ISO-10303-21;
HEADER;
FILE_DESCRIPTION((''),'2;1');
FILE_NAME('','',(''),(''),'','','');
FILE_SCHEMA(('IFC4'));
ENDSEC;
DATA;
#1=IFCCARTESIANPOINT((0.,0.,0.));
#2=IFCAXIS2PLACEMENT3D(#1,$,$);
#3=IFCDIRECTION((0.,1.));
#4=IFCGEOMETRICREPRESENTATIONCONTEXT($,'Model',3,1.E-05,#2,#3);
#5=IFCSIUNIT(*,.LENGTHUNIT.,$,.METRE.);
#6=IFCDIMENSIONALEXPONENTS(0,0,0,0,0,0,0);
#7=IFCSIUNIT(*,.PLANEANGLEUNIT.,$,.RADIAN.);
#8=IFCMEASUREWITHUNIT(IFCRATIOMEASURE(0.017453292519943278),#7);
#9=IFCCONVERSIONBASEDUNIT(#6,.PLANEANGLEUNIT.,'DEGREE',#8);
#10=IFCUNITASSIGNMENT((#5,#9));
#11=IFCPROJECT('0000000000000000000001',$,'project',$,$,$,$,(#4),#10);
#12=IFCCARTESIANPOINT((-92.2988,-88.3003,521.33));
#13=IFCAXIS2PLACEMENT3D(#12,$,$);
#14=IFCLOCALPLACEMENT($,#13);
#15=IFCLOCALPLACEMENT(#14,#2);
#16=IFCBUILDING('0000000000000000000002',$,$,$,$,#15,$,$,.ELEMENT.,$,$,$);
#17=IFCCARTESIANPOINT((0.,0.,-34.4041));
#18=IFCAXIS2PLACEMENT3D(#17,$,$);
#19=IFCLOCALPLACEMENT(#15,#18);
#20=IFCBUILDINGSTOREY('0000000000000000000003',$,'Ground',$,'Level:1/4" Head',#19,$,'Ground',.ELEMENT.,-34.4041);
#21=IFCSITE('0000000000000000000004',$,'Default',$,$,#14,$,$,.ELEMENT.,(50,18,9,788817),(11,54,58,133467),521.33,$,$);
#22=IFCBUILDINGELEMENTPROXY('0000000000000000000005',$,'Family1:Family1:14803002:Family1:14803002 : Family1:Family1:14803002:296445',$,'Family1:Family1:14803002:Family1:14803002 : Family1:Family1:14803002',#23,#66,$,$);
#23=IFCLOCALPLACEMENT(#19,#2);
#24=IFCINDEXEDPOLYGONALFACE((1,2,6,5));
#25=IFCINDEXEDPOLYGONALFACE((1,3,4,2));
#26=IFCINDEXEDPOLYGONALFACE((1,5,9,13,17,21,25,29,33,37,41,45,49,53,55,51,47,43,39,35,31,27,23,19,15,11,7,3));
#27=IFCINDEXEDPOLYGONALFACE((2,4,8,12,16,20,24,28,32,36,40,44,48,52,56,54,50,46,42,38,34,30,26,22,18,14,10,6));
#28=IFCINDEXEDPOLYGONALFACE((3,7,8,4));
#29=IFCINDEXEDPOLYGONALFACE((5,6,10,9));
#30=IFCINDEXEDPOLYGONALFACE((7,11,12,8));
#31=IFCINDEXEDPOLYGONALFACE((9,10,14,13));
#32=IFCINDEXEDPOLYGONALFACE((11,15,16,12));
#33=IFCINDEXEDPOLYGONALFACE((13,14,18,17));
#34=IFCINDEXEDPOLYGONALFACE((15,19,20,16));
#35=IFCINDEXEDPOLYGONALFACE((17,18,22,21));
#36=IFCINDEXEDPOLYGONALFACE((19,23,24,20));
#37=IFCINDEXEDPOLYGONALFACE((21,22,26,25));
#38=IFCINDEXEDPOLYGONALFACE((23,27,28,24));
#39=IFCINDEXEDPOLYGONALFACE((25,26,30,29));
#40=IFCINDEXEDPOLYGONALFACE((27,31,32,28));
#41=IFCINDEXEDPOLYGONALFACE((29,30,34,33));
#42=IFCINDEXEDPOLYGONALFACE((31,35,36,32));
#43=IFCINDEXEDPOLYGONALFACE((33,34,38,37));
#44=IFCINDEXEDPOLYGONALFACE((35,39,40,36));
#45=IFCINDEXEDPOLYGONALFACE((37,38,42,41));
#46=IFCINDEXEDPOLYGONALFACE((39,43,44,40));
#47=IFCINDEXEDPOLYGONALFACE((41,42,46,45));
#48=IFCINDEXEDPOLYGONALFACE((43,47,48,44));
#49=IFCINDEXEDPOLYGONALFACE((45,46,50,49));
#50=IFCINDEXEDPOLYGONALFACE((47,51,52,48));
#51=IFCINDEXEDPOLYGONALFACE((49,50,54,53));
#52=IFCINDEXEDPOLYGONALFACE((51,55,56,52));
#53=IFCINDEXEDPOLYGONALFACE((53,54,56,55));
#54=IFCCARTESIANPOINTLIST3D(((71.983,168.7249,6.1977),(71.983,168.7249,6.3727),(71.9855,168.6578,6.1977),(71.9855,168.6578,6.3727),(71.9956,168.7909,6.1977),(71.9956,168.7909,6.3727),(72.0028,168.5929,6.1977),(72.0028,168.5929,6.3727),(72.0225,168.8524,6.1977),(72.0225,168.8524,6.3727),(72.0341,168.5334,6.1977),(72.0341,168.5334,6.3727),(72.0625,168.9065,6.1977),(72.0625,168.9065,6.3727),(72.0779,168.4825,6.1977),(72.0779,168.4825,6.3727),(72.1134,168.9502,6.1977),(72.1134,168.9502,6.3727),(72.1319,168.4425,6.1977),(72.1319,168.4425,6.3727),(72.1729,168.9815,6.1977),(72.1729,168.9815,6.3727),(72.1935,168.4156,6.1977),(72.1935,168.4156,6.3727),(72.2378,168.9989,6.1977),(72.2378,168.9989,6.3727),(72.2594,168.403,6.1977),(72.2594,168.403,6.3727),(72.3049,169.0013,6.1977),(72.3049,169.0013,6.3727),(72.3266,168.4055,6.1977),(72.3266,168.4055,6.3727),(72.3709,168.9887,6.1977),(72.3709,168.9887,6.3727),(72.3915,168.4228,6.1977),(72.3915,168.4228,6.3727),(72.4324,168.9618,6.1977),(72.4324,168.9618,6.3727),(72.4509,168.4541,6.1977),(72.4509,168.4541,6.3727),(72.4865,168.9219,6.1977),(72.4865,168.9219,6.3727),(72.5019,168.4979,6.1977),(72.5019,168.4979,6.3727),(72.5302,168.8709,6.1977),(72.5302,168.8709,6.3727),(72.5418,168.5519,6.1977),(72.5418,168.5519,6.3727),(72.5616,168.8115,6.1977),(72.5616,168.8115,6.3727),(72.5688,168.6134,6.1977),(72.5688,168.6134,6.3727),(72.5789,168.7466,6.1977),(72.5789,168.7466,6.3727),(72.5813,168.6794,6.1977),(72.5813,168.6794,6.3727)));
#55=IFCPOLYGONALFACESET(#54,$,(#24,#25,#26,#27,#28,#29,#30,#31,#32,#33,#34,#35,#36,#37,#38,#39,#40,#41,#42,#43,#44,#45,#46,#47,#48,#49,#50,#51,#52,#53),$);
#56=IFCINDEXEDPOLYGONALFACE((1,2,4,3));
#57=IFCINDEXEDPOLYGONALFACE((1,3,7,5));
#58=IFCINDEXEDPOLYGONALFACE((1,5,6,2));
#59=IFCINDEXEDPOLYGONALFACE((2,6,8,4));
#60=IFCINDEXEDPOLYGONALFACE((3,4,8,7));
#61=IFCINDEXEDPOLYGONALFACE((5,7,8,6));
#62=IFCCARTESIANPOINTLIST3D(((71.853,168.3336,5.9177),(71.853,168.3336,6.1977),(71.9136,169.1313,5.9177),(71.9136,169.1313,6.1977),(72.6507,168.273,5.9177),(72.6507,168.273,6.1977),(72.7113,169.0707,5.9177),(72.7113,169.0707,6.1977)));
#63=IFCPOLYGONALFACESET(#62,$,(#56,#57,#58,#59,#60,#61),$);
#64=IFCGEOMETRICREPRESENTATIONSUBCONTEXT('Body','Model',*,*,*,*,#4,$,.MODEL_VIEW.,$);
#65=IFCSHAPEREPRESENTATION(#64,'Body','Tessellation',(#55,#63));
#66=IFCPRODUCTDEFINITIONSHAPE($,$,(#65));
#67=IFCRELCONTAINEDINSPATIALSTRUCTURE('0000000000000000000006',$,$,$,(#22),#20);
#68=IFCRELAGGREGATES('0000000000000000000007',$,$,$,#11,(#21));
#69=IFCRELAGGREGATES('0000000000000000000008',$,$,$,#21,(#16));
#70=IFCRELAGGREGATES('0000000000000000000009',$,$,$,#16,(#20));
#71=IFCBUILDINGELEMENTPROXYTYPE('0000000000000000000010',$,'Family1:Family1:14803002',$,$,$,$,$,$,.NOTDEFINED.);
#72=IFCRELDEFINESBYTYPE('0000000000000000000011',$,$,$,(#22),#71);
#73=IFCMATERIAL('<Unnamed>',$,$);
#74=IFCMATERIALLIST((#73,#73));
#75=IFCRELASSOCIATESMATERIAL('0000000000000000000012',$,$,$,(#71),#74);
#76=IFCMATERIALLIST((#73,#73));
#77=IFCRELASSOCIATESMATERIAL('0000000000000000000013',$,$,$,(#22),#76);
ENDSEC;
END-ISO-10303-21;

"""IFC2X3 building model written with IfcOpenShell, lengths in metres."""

from ifc_helpers import new_model, entity, si_unit, converted_unit, direction, frame, origin, origin_2d_with_axis, place, context, subcontext, project, spatial, rectangle, circle, extrude, source, transform, mapped, material, material_list, type_object, type_shapes, element, save


model = new_model("IFC2X3")

# Units and contexts
model_context = context("Model", 3, precision=1e-05, world=origin(), true_north=direction((0.0, 1.0)))
body_context = subcontext(model_context, "Body", "Model", "MODEL_VIEW")
ifc_project = project(units=[si_unit("LENGTHUNIT", "METRE"), converted_unit("PLANEANGLEUNIT", "DEGREE", entity("IfcRatioMeasure", 0.017453292519943278), si_unit("PLANEANGLEUNIT", "RADIAN"), dimensions=[0, 0, 0, 0, 0, 0, 0])], contexts=[model_context])

# Site, building, storey
site_placement = place(None, frame((-92.2988, -88.3003, 521.33)))
site = spatial("IfcSite", under=ifc_project, at=site_placement, Name="Default", CompositionType="ELEMENT", RefLatitude=(50, 18, 9, 788817), RefLongitude=(11, 54, 58, 133467), RefElevation=521.33)
building_placement = place(site_placement, origin())
building = spatial("IfcBuilding", under=site, at=building_placement, CompositionType="ELEMENT")
storey_placement = place(building_placement, frame((0.0, 0.0, -34.4041)))
storey = spatial("IfcBuildingStorey", under=building, at=storey_placement, Name="Ground", ObjectType="Level:1/4\" Head", LongName="Ground", CompositionType="ELEMENT", Elevation=-34.4041)

# Building element proxy
ifc_material_1 = material(Name="<Unnamed>")
ifc_material_list_1 = material_list([ifc_material_1, ifc_material_1])
ifc_material_list_2 = material_list([ifc_material_1, ifc_material_1])
building_element_proxy_type_1 = type_object("IfcBuildingElementProxyType", Name="Family1:Family1:14803002", PredefinedType="NOTDEFINED", material=ifc_material_list_2)
shared_shape_1 = source(origin(), body_context, "Body", "SweptSolid", [
    extrude(circle(Radius=0.3, at=origin_2d_with_axis()), frame((72.2822, 168.7022, -28.2064), z_axis=(0.0, 0.0, 1.0), x_axis=(0.997125, -0.07577, 0.0)), (0.0, 0.0, 1.0), 0.175),
    extrude(rectangle(XDim=0.8, YDim=0.8, at=origin_2d_with_axis()), frame((72.2822, 168.7022, -28.4864), z_axis=(0.0, 0.0, 1.0), x_axis=(-0.07577, -0.997125, 0.0)), (0.0, 0.0, 1.0), 0.28),
])
type_shapes(building_element_proxy_type_1, [shared_shape_1])
proxy_1_placement = place(storey_placement, frame((0.0, 0.0, 34.4041)))
element("IfcBuildingElementProxy", 1, at=proxy_1_placement, inside=storey, type_object=building_element_proxy_type_1, material=ifc_material_list_1, Name="Family1:Family1:14803002:Family1:14803002 : Family1:Family1:14803002:296445", ObjectType="Family1:Family1:14803002:Family1:14803002 : Family1:Family1:14803002", context=body_context, shape_type="MappedRepresentation", body=[
    mapped(shared_shape_1, transform((0.0, 0.0, 0.0), scale=1.0)),
])

save(model, "model.ifc")
